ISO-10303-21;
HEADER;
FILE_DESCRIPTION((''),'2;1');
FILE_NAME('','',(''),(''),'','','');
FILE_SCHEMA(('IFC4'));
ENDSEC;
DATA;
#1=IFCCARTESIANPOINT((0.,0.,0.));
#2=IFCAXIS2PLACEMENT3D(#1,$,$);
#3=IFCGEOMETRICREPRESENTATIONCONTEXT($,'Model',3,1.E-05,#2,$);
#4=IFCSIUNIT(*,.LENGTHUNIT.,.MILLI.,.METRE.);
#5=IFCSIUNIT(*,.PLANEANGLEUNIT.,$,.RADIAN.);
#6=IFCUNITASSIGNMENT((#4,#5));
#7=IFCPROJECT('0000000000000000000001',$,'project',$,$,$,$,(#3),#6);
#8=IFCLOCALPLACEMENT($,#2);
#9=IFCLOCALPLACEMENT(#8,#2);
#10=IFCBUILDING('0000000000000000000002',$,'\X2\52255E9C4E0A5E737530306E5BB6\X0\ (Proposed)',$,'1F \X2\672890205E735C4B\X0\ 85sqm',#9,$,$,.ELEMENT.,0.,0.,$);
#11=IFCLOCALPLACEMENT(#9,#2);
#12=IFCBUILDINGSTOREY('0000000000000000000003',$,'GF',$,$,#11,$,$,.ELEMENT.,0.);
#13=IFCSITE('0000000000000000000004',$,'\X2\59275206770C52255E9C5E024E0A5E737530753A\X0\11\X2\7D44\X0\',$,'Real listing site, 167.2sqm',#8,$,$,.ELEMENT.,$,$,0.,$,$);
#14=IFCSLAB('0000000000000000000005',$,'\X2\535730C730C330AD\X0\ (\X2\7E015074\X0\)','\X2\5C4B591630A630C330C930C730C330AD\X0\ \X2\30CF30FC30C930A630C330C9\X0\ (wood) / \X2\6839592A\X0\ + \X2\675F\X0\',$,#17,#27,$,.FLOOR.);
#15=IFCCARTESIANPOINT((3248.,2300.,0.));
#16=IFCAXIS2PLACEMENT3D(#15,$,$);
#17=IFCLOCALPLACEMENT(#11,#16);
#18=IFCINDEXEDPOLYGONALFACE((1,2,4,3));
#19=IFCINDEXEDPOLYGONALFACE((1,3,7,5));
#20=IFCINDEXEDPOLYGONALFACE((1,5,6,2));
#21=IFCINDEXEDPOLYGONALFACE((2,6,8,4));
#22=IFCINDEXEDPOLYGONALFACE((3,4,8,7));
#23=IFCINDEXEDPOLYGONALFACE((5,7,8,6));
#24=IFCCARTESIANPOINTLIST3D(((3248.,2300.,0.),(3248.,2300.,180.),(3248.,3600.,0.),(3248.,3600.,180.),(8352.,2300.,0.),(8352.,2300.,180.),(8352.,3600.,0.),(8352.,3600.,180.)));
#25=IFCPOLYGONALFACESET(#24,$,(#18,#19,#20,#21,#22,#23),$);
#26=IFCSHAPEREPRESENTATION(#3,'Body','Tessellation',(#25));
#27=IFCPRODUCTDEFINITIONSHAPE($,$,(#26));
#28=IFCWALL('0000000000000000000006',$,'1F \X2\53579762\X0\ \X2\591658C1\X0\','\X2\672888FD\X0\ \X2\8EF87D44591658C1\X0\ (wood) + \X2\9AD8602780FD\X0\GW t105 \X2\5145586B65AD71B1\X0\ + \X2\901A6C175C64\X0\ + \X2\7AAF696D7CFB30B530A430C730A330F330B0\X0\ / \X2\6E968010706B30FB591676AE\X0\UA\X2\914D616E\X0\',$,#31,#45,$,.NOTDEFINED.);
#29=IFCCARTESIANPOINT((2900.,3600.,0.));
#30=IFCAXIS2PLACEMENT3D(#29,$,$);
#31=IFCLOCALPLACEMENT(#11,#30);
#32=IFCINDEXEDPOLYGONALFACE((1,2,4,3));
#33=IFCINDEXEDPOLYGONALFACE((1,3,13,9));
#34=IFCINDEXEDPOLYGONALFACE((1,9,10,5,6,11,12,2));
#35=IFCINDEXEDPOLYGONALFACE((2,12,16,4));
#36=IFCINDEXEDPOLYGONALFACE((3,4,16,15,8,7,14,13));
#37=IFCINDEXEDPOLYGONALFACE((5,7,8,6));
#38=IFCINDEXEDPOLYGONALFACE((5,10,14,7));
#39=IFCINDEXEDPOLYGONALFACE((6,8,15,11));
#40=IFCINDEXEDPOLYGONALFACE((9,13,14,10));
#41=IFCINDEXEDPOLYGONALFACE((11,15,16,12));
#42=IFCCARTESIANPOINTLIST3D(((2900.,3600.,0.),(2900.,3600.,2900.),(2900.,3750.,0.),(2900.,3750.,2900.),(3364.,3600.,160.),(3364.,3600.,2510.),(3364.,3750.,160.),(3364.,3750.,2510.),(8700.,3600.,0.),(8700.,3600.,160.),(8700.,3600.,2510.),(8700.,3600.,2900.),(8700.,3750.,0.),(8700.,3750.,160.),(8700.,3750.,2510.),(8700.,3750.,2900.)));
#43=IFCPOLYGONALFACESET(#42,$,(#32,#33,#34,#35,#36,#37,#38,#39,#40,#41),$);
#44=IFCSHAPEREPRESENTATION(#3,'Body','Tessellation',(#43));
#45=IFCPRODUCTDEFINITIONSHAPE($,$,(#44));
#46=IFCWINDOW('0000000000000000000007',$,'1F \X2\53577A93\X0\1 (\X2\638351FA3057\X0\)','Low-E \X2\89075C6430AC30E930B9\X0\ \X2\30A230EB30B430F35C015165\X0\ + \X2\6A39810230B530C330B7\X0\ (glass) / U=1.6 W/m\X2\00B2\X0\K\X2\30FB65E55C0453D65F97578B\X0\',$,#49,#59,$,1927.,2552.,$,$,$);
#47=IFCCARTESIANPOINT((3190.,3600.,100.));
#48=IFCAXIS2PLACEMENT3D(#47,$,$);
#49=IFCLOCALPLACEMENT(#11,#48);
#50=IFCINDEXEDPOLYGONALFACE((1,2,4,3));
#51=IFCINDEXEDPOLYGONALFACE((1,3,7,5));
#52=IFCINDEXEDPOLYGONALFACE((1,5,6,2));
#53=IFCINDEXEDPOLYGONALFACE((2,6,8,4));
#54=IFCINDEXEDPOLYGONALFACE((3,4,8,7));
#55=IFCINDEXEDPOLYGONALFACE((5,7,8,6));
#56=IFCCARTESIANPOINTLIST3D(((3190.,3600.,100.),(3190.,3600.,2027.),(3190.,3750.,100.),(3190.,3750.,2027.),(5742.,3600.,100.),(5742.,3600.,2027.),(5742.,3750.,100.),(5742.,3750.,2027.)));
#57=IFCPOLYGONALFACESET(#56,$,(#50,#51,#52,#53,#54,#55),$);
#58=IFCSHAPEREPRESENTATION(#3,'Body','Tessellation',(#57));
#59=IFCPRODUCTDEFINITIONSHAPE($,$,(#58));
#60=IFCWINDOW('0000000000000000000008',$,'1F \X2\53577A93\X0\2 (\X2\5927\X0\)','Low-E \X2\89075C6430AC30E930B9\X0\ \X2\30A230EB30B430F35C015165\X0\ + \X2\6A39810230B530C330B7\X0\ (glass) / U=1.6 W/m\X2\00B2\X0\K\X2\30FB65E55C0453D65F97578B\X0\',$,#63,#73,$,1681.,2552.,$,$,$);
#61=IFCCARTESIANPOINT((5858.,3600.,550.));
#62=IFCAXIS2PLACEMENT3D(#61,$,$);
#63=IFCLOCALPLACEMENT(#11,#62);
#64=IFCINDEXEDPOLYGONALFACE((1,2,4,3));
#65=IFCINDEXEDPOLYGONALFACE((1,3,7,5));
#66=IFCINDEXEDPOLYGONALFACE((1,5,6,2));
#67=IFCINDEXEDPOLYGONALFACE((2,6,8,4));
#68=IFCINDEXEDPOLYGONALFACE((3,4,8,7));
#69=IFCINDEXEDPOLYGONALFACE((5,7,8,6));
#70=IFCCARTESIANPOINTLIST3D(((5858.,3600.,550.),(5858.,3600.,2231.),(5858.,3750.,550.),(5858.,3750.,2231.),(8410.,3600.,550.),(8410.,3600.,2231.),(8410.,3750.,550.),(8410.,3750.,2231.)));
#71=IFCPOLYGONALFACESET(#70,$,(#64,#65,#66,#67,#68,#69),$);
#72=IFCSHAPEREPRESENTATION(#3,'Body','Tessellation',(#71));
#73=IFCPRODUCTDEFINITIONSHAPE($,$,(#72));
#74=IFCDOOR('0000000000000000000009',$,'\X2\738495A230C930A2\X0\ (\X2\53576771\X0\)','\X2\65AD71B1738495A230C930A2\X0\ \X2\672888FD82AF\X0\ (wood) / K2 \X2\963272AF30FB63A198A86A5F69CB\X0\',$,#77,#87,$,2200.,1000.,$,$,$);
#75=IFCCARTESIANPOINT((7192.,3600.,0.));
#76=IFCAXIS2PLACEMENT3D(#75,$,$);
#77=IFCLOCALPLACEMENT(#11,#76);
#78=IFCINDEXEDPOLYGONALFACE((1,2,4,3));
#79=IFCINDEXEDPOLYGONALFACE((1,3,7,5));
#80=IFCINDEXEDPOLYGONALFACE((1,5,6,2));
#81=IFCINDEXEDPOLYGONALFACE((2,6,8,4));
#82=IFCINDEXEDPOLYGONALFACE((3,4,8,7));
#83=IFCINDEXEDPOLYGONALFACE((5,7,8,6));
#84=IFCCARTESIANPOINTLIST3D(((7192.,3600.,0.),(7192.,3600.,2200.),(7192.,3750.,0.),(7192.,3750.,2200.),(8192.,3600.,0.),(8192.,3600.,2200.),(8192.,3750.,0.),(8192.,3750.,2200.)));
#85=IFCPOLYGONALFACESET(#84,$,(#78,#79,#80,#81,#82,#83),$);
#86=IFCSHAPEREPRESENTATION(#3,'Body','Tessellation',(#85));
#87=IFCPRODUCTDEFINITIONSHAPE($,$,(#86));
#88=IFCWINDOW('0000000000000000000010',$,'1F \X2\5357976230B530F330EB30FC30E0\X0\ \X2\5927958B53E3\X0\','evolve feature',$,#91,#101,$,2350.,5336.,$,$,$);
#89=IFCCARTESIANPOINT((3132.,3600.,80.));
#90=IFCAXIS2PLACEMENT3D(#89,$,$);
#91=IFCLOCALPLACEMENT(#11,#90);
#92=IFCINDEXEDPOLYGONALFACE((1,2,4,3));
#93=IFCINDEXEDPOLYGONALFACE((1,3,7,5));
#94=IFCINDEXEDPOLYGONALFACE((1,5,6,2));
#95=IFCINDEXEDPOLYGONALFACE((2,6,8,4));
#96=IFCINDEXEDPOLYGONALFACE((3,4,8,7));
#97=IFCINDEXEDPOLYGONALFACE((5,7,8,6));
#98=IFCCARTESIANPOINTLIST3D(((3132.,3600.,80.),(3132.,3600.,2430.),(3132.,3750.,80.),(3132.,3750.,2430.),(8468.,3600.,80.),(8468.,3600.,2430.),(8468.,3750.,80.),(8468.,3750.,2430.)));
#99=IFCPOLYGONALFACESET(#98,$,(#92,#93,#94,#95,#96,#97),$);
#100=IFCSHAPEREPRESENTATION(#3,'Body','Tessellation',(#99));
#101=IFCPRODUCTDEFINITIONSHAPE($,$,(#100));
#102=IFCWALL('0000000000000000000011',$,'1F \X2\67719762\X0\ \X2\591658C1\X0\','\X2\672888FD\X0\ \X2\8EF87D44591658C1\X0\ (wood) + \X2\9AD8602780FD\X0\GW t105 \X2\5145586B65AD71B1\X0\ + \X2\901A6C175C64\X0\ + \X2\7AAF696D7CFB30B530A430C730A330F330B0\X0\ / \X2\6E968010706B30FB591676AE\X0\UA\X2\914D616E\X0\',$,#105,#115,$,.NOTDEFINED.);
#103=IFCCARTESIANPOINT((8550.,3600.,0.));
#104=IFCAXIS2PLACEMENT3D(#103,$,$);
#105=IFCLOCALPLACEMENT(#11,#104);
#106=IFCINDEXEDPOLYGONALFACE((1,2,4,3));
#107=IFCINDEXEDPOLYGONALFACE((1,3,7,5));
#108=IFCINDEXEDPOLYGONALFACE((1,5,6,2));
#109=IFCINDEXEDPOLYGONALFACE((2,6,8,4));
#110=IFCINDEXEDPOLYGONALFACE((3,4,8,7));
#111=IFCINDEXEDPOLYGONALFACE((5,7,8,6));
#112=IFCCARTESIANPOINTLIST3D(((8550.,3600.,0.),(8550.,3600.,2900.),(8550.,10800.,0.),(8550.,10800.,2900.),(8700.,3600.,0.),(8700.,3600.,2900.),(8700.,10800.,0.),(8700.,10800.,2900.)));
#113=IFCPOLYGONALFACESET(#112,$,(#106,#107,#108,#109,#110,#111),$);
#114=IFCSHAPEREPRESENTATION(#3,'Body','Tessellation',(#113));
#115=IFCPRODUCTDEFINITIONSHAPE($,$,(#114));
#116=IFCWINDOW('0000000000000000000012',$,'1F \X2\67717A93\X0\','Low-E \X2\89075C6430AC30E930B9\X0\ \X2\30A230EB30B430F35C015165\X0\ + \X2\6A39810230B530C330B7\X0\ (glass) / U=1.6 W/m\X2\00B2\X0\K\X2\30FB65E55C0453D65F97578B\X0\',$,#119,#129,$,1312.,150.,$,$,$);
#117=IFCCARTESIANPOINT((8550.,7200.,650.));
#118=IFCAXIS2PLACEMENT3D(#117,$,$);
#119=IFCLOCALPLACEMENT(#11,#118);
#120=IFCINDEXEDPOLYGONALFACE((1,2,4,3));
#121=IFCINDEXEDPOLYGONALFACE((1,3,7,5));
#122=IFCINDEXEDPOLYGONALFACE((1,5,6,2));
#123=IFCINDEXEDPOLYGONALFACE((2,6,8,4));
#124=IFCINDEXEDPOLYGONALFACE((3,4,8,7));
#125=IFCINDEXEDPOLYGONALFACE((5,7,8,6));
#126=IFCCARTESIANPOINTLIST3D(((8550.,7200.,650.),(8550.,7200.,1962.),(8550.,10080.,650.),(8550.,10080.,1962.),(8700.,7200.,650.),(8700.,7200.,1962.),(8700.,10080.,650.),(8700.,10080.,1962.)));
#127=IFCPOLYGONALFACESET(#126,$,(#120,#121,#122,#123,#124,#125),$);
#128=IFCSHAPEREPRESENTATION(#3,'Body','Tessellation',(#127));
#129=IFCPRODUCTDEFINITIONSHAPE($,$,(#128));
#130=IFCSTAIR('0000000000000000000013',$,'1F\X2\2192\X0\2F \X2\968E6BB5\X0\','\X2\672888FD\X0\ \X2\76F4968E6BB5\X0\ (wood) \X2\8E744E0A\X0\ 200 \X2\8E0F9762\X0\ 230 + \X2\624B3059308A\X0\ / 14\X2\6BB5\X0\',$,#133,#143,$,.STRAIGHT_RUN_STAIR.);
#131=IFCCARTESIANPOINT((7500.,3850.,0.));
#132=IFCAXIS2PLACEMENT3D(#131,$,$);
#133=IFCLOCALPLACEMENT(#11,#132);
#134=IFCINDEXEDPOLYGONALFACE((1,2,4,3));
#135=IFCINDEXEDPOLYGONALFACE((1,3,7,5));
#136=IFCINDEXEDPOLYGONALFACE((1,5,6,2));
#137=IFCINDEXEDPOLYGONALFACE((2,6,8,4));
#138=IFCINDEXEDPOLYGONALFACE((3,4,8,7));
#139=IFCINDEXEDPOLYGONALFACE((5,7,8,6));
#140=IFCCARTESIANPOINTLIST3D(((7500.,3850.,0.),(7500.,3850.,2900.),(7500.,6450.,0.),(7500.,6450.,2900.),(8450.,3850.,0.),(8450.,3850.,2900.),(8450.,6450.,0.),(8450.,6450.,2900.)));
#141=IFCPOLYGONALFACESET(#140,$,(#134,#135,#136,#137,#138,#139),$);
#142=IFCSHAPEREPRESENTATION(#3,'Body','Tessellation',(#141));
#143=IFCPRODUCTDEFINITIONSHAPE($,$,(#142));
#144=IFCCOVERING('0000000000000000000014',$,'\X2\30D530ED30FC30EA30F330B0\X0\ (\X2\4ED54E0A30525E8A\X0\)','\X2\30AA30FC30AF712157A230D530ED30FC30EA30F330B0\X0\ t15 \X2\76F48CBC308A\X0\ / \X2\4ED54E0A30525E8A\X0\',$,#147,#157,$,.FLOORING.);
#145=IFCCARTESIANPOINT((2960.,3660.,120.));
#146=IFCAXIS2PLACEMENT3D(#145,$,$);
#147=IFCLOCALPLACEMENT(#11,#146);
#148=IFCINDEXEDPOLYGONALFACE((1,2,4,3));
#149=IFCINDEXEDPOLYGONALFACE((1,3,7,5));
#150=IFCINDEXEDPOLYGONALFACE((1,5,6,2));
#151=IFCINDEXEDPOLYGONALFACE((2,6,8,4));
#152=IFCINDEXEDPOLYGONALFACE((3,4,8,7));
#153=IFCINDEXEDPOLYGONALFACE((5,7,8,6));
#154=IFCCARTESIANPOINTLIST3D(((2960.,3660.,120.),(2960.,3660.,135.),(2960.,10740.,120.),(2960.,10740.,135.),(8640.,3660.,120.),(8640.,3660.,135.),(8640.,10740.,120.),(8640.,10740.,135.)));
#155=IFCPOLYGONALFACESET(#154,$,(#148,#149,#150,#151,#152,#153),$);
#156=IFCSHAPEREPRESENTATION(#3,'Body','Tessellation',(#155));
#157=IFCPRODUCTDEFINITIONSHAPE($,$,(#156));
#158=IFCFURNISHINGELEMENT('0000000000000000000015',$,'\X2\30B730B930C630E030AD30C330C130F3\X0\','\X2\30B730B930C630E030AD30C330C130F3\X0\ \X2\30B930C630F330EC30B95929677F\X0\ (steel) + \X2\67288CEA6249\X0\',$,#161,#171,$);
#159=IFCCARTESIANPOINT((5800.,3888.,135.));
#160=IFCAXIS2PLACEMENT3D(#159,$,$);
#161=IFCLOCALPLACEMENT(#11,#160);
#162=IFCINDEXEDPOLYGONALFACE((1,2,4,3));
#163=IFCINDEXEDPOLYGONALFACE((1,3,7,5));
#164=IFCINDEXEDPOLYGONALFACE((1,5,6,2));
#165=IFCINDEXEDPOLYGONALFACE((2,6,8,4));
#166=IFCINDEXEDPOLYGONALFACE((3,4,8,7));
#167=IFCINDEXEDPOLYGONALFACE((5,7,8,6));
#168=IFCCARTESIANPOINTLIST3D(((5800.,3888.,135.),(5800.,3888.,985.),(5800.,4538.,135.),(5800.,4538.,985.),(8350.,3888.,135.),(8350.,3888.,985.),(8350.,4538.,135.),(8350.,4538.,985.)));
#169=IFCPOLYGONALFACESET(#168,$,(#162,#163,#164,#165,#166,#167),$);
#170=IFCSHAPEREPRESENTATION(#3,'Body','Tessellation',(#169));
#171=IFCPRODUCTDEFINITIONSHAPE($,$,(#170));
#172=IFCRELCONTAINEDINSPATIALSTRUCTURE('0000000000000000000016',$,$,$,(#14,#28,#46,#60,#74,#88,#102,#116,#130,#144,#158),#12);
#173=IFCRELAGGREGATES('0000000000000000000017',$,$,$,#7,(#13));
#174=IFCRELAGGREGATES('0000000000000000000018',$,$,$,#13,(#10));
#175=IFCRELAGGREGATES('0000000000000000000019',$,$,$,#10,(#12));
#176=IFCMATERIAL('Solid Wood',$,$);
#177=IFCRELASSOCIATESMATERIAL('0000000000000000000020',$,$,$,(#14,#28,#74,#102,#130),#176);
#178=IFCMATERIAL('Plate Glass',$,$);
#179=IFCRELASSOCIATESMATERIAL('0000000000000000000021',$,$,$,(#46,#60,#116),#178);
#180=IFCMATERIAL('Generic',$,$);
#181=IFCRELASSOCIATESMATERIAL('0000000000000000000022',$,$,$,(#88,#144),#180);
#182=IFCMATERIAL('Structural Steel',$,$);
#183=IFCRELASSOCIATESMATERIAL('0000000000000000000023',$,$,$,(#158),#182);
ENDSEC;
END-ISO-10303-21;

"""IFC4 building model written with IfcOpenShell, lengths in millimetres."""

from ifc_helpers import new_model, si_unit, frame, frame_2d, origin, place, context, project, spatial, rectangle, extrude, material, element, fill, save


model = new_model("IFC4")

# Units and contexts
model_context = context("Model", 3, precision=1e-05, world=origin())
ifc_project = project(units=[si_unit("LENGTHUNIT", "METRE", prefix="MILLI"), si_unit("PLANEANGLEUNIT", "RADIAN")], contexts=[model_context])

# Site, building, storey
site_placement = place(None, origin())
site = spatial("IfcSite", under=ifc_project, at=site_placement, Name="大分県別府市上平田町11組", ObjectType="Real listing site, 167.2sqm", CompositionType="ELEMENT", RefElevation=0.0)
building_placement = place(site_placement, origin())
building = spatial("IfcBuilding", under=site, at=building_placement, Name="別府上平田の家 (Proposed)", ObjectType="1F 木造平屋 85sqm", CompositionType="ELEMENT", ElevationOfRefHeight=0.0, ElevationOfTerrain=0.0)
storey_placement = place(building_placement, origin())
storey = spatial("IfcBuildingStorey", under=building, at=storey_placement, Name="GF", CompositionType="ELEMENT", Elevation=0.0)

# Slab
ifc_material_1 = material(Name="Solid Wood")
slab_1_placement = place(storey_placement, frame((3248.0, 2300.0, 0.0)))
element("IfcSlab", 1, at=slab_1_placement, inside=storey, material=ifc_material_1, Name="南デッキ (縁側)", Description="屋外ウッドデッキ ハードウッド (wood) / 根太 + 束", PredefinedType="FLOOR", context=model_context, shape_type="SweptSolid", body=[
    extrude(rectangle(XDim=5104.0, YDim=1300.0, at=frame_2d((2552.0, 650.0))), frame((3248.0, 2300.0, 0.0)), (0.0, 0.0, 1.0), 180.0),
])
ifc_material_2 = material(Name="Generic")

# Wall, openings, windows, door
wall_1_placement = place(storey_placement, frame((2900.0, 3600.0, 0.0)))
wall_1 = element("IfcWall", 2, at=wall_1_placement, inside=storey, material=ifc_material_1, Name="1F 南面 外壁", Description="木製 軸組外壁 (wood) + 高性能GW t105 充填断熱 + 通気層 + 窯業系サイディング / 準耐火・外皮UA配慮", PredefinedType="NOTDEFINED", context=model_context, shape_type="SweptSolid", body=[
    extrude(rectangle(XDim=5800.0, YDim=150.0, at=frame_2d((2900.0, 75.0))), frame((2900.0, 3600.0, 0.0)), (0.0, 0.0, 1.0), 2900.0),
])
opening_1_placement = place(storey_placement, frame((3190.0, 3600.0, 100.0)))
opening_1 = element("IfcOpeningElement", 3, at=opening_1_placement, cuts=wall_1, PredefinedType="NOTDEFINED", context=model_context, shape_type="SweptSolid", body=[
    extrude(rectangle(XDim=2552.0, YDim=150.0, at=frame_2d((1276.0, 75.0))), frame((3190.0, 3600.0, 100.0)), (0.0, 0.0, 1.0), 1927.0),
])
opening_2_placement = place(storey_placement, frame((5858.0, 3600.0, 550.0)))
opening_2 = element("IfcOpeningElement", 4, at=opening_2_placement, cuts=wall_1, PredefinedType="NOTDEFINED", context=model_context, shape_type="SweptSolid", body=[
    extrude(rectangle(XDim=2552.0, YDim=150.0, at=frame_2d((1276.0, 75.0))), frame((5858.0, 3600.0, 550.0)), (0.0, 0.0, 1.0), 1681.0),
])
opening_3_placement = place(storey_placement, frame((7192.0, 3600.0, 0.0)))
opening_3 = element("IfcOpeningElement", 5, at=opening_3_placement, cuts=wall_1, PredefinedType="NOTDEFINED", context=model_context, shape_type="SweptSolid", body=[
    extrude(rectangle(XDim=1000.0, YDim=150.0, at=frame_2d((500.0, 75.0))), frame((7192.0, 3600.0, 0.0)), (0.0, 0.0, 1.0), 2200.0),
])
opening_4_placement = place(storey_placement, frame((3132.0, 3600.0, 80.0)))
opening_4 = element("IfcOpeningElement", 6, at=opening_4_placement, cuts=wall_1, PredefinedType="NOTDEFINED", context=model_context, shape_type="SweptSolid", body=[
    extrude(rectangle(XDim=5336.0, YDim=150.0, at=frame_2d((2668.0, 75.0))), frame((3132.0, 3600.0, 80.0)), (0.0, 0.0, 1.0), 2350.0),
])
ifc_material_3 = material(Name="Plate Glass")
window_1_placement = place(storey_placement, frame((3190.0, 3600.0, 100.0)))
window_1 = element("IfcWindow", 7, at=window_1_placement, inside=storey, material=ifc_material_3, Name="1F 南窓1 (掃出し)", Description="Low-E 複層ガラス アルゴン封入 + 樹脂サッシ (glass) / U=1.6 W/m²K・日射取得型", OverallHeight=1927.0, OverallWidth=2552.0, context=model_context, shape_type="SweptSolid", body=[
    extrude(rectangle(XDim=2552.0, YDim=150.0, at=frame_2d((1276.0, 75.0))), frame((3190.0, 3600.0, 100.0)), (0.0, 0.0, 1.0), 1927.0),
])
fill(opening_1, window_1)
window_2_placement = place(storey_placement, frame((5858.0, 3600.0, 550.0)))
window_2 = element("IfcWindow", 8, at=window_2_placement, inside=storey, material=ifc_material_3, Name="1F 南窓2 (大)", Description="Low-E 複層ガラス アルゴン封入 + 樹脂サッシ (glass) / U=1.6 W/m²K・日射取得型", OverallHeight=1681.0, OverallWidth=2552.0, context=model_context, shape_type="SweptSolid", body=[
    extrude(rectangle(XDim=2552.0, YDim=150.0, at=frame_2d((1276.0, 75.0))), frame((5858.0, 3600.0, 550.0)), (0.0, 0.0, 1.0), 1681.0),
])
fill(opening_2, window_2)
door_placement = place(storey_placement, frame((7192.0, 3600.0, 0.0)))
door = element("IfcDoor", 9, at=door_placement, inside=storey, material=ifc_material_1, Name="玄関ドア (南東)", Description="断熱玄関ドア 木製芯 (wood) / K2 防犯・採風機構", OverallHeight=2200.0, OverallWidth=1000.0, context=model_context, shape_type="SweptSolid", body=[
    extrude(rectangle(XDim=1000.0, YDim=150.0, at=frame_2d((500.0, 75.0))), frame((7192.0, 3600.0, 0.0)), (0.0, 0.0, 1.0), 2200.0),
])
fill(opening_3, door)
window_3_placement = place(storey_placement, frame((3132.0, 3600.0, 80.0)))
window_3 = element("IfcWindow", 10, at=window_3_placement, inside=storey, material=ifc_material_2, Name="1F 南面サンルーム 大開口", Description="evolve feature", OverallHeight=2350.0, OverallWidth=5336.0, context=model_context, shape_type="SweptSolid", body=[
    extrude(rectangle(XDim=5336.0, YDim=150.0, at=frame_2d((2668.0, 75.0))), frame((3132.0, 3600.0, 80.0)), (0.0, 0.0, 1.0), 2350.0),
])
fill(opening_4, window_3)

# Wall, opening, window
wall_2_placement = place(storey_placement, frame((8550.0, 3600.0, 0.0)))
wall_2 = element("IfcWall", 11, at=wall_2_placement, inside=storey, material=ifc_material_1, Name="1F 東面 外壁", Description="木製 軸組外壁 (wood) + 高性能GW t105 充填断熱 + 通気層 + 窯業系サイディング / 準耐火・外皮UA配慮", PredefinedType="NOTDEFINED", context=model_context, shape_type="SweptSolid", body=[
    extrude(rectangle(XDim=150.0, YDim=7200.0, at=frame_2d((75.0, 3600.0))), frame((8550.0, 3600.0, 0.0)), (0.0, 0.0, 1.0), 2900.0),
])
opening_5_placement = place(storey_placement, frame((8550.0, 7200.0, 650.0)))
opening_5 = element("IfcOpeningElement", 12, at=opening_5_placement, cuts=wall_2, PredefinedType="NOTDEFINED", context=model_context, shape_type="SweptSolid", body=[
    extrude(rectangle(XDim=150.0, YDim=2880.0, at=frame_2d((75.0, 1440.0))), frame((8550.0, 7200.0, 650.0)), (0.0, 0.0, 1.0), 1312.0),
])
window_4_placement = place(storey_placement, frame((8550.0, 7200.0, 650.0)))
window_4 = element("IfcWindow", 13, at=window_4_placement, inside=storey, material=ifc_material_3, Name="1F 東窓", Description="Low-E 複層ガラス アルゴン封入 + 樹脂サッシ (glass) / U=1.6 W/m²K・日射取得型", OverallHeight=1312.0, OverallWidth=150.0, context=model_context, shape_type="SweptSolid", body=[
    extrude(rectangle(XDim=150.0, YDim=2880.0, at=frame_2d((75.0, 1440.0))), frame((8550.0, 7200.0, 650.0)), (0.0, 0.0, 1.0), 1312.0),
])
fill(opening_5, window_4)

# Stair
stair_placement = place(storey_placement, frame((7500.0, 3850.0, 0.0)))
element("IfcStair", 14, at=stair_placement, inside=storey, material=ifc_material_1, Name="1F→2F 階段", Description="木製 直階段 (wood) 蹴上 200 踏面 230 + 手すり / 14段", PredefinedType="STRAIGHT_RUN_STAIR", context=model_context, shape_type="SweptSolid", body=[
    extrude(rectangle(XDim=950.0, YDim=2600.0, at=frame_2d((475.0, 1300.0))), frame((7500.0, 3850.0, 0.0)), (0.0, 0.0, 1.0), 2900.0),
])

# Covering
covering_placement = place(storey_placement, frame((2960.0, 3660.0, 120.0)))
element("IfcCovering", 15, at=covering_placement, inside=storey, material=ifc_material_2, Name="フローリング (仕上げ床)", Description="オーク無垢フローリング t15 直貼り / 仕上げ床", PredefinedType="FLOORING", context=model_context, shape_type="SweptSolid", body=[
    extrude(rectangle(XDim=5680.0, YDim=7080.0, at=frame_2d((2840.0, 3540.0))), frame((2960.0, 3660.0, 120.0)), (0.0, 0.0, 1.0), 15.0),
])

# Furnishing element
ifc_material_4 = material(Name="Structural Steel")
furnishing_placement = place(storey_placement, frame((5800.0, 3888.0, 135.0)))
element("IfcFurnishingElement", 16, at=furnishing_placement, inside=storey, material=ifc_material_4, Name="システムキッチン", Description="システムキッチン ステンレス天板 (steel) + 木質扉", context=model_context, shape_type="SweptSolid", body=[
    extrude(rectangle(XDim=2550.0, YDim=650.0, at=frame_2d((1275.0, 325.0))), frame((5800.0, 3888.0, 135.0)), (0.0, 0.0, 1.0), 850.0),
])

save(model, "model.ifc")
